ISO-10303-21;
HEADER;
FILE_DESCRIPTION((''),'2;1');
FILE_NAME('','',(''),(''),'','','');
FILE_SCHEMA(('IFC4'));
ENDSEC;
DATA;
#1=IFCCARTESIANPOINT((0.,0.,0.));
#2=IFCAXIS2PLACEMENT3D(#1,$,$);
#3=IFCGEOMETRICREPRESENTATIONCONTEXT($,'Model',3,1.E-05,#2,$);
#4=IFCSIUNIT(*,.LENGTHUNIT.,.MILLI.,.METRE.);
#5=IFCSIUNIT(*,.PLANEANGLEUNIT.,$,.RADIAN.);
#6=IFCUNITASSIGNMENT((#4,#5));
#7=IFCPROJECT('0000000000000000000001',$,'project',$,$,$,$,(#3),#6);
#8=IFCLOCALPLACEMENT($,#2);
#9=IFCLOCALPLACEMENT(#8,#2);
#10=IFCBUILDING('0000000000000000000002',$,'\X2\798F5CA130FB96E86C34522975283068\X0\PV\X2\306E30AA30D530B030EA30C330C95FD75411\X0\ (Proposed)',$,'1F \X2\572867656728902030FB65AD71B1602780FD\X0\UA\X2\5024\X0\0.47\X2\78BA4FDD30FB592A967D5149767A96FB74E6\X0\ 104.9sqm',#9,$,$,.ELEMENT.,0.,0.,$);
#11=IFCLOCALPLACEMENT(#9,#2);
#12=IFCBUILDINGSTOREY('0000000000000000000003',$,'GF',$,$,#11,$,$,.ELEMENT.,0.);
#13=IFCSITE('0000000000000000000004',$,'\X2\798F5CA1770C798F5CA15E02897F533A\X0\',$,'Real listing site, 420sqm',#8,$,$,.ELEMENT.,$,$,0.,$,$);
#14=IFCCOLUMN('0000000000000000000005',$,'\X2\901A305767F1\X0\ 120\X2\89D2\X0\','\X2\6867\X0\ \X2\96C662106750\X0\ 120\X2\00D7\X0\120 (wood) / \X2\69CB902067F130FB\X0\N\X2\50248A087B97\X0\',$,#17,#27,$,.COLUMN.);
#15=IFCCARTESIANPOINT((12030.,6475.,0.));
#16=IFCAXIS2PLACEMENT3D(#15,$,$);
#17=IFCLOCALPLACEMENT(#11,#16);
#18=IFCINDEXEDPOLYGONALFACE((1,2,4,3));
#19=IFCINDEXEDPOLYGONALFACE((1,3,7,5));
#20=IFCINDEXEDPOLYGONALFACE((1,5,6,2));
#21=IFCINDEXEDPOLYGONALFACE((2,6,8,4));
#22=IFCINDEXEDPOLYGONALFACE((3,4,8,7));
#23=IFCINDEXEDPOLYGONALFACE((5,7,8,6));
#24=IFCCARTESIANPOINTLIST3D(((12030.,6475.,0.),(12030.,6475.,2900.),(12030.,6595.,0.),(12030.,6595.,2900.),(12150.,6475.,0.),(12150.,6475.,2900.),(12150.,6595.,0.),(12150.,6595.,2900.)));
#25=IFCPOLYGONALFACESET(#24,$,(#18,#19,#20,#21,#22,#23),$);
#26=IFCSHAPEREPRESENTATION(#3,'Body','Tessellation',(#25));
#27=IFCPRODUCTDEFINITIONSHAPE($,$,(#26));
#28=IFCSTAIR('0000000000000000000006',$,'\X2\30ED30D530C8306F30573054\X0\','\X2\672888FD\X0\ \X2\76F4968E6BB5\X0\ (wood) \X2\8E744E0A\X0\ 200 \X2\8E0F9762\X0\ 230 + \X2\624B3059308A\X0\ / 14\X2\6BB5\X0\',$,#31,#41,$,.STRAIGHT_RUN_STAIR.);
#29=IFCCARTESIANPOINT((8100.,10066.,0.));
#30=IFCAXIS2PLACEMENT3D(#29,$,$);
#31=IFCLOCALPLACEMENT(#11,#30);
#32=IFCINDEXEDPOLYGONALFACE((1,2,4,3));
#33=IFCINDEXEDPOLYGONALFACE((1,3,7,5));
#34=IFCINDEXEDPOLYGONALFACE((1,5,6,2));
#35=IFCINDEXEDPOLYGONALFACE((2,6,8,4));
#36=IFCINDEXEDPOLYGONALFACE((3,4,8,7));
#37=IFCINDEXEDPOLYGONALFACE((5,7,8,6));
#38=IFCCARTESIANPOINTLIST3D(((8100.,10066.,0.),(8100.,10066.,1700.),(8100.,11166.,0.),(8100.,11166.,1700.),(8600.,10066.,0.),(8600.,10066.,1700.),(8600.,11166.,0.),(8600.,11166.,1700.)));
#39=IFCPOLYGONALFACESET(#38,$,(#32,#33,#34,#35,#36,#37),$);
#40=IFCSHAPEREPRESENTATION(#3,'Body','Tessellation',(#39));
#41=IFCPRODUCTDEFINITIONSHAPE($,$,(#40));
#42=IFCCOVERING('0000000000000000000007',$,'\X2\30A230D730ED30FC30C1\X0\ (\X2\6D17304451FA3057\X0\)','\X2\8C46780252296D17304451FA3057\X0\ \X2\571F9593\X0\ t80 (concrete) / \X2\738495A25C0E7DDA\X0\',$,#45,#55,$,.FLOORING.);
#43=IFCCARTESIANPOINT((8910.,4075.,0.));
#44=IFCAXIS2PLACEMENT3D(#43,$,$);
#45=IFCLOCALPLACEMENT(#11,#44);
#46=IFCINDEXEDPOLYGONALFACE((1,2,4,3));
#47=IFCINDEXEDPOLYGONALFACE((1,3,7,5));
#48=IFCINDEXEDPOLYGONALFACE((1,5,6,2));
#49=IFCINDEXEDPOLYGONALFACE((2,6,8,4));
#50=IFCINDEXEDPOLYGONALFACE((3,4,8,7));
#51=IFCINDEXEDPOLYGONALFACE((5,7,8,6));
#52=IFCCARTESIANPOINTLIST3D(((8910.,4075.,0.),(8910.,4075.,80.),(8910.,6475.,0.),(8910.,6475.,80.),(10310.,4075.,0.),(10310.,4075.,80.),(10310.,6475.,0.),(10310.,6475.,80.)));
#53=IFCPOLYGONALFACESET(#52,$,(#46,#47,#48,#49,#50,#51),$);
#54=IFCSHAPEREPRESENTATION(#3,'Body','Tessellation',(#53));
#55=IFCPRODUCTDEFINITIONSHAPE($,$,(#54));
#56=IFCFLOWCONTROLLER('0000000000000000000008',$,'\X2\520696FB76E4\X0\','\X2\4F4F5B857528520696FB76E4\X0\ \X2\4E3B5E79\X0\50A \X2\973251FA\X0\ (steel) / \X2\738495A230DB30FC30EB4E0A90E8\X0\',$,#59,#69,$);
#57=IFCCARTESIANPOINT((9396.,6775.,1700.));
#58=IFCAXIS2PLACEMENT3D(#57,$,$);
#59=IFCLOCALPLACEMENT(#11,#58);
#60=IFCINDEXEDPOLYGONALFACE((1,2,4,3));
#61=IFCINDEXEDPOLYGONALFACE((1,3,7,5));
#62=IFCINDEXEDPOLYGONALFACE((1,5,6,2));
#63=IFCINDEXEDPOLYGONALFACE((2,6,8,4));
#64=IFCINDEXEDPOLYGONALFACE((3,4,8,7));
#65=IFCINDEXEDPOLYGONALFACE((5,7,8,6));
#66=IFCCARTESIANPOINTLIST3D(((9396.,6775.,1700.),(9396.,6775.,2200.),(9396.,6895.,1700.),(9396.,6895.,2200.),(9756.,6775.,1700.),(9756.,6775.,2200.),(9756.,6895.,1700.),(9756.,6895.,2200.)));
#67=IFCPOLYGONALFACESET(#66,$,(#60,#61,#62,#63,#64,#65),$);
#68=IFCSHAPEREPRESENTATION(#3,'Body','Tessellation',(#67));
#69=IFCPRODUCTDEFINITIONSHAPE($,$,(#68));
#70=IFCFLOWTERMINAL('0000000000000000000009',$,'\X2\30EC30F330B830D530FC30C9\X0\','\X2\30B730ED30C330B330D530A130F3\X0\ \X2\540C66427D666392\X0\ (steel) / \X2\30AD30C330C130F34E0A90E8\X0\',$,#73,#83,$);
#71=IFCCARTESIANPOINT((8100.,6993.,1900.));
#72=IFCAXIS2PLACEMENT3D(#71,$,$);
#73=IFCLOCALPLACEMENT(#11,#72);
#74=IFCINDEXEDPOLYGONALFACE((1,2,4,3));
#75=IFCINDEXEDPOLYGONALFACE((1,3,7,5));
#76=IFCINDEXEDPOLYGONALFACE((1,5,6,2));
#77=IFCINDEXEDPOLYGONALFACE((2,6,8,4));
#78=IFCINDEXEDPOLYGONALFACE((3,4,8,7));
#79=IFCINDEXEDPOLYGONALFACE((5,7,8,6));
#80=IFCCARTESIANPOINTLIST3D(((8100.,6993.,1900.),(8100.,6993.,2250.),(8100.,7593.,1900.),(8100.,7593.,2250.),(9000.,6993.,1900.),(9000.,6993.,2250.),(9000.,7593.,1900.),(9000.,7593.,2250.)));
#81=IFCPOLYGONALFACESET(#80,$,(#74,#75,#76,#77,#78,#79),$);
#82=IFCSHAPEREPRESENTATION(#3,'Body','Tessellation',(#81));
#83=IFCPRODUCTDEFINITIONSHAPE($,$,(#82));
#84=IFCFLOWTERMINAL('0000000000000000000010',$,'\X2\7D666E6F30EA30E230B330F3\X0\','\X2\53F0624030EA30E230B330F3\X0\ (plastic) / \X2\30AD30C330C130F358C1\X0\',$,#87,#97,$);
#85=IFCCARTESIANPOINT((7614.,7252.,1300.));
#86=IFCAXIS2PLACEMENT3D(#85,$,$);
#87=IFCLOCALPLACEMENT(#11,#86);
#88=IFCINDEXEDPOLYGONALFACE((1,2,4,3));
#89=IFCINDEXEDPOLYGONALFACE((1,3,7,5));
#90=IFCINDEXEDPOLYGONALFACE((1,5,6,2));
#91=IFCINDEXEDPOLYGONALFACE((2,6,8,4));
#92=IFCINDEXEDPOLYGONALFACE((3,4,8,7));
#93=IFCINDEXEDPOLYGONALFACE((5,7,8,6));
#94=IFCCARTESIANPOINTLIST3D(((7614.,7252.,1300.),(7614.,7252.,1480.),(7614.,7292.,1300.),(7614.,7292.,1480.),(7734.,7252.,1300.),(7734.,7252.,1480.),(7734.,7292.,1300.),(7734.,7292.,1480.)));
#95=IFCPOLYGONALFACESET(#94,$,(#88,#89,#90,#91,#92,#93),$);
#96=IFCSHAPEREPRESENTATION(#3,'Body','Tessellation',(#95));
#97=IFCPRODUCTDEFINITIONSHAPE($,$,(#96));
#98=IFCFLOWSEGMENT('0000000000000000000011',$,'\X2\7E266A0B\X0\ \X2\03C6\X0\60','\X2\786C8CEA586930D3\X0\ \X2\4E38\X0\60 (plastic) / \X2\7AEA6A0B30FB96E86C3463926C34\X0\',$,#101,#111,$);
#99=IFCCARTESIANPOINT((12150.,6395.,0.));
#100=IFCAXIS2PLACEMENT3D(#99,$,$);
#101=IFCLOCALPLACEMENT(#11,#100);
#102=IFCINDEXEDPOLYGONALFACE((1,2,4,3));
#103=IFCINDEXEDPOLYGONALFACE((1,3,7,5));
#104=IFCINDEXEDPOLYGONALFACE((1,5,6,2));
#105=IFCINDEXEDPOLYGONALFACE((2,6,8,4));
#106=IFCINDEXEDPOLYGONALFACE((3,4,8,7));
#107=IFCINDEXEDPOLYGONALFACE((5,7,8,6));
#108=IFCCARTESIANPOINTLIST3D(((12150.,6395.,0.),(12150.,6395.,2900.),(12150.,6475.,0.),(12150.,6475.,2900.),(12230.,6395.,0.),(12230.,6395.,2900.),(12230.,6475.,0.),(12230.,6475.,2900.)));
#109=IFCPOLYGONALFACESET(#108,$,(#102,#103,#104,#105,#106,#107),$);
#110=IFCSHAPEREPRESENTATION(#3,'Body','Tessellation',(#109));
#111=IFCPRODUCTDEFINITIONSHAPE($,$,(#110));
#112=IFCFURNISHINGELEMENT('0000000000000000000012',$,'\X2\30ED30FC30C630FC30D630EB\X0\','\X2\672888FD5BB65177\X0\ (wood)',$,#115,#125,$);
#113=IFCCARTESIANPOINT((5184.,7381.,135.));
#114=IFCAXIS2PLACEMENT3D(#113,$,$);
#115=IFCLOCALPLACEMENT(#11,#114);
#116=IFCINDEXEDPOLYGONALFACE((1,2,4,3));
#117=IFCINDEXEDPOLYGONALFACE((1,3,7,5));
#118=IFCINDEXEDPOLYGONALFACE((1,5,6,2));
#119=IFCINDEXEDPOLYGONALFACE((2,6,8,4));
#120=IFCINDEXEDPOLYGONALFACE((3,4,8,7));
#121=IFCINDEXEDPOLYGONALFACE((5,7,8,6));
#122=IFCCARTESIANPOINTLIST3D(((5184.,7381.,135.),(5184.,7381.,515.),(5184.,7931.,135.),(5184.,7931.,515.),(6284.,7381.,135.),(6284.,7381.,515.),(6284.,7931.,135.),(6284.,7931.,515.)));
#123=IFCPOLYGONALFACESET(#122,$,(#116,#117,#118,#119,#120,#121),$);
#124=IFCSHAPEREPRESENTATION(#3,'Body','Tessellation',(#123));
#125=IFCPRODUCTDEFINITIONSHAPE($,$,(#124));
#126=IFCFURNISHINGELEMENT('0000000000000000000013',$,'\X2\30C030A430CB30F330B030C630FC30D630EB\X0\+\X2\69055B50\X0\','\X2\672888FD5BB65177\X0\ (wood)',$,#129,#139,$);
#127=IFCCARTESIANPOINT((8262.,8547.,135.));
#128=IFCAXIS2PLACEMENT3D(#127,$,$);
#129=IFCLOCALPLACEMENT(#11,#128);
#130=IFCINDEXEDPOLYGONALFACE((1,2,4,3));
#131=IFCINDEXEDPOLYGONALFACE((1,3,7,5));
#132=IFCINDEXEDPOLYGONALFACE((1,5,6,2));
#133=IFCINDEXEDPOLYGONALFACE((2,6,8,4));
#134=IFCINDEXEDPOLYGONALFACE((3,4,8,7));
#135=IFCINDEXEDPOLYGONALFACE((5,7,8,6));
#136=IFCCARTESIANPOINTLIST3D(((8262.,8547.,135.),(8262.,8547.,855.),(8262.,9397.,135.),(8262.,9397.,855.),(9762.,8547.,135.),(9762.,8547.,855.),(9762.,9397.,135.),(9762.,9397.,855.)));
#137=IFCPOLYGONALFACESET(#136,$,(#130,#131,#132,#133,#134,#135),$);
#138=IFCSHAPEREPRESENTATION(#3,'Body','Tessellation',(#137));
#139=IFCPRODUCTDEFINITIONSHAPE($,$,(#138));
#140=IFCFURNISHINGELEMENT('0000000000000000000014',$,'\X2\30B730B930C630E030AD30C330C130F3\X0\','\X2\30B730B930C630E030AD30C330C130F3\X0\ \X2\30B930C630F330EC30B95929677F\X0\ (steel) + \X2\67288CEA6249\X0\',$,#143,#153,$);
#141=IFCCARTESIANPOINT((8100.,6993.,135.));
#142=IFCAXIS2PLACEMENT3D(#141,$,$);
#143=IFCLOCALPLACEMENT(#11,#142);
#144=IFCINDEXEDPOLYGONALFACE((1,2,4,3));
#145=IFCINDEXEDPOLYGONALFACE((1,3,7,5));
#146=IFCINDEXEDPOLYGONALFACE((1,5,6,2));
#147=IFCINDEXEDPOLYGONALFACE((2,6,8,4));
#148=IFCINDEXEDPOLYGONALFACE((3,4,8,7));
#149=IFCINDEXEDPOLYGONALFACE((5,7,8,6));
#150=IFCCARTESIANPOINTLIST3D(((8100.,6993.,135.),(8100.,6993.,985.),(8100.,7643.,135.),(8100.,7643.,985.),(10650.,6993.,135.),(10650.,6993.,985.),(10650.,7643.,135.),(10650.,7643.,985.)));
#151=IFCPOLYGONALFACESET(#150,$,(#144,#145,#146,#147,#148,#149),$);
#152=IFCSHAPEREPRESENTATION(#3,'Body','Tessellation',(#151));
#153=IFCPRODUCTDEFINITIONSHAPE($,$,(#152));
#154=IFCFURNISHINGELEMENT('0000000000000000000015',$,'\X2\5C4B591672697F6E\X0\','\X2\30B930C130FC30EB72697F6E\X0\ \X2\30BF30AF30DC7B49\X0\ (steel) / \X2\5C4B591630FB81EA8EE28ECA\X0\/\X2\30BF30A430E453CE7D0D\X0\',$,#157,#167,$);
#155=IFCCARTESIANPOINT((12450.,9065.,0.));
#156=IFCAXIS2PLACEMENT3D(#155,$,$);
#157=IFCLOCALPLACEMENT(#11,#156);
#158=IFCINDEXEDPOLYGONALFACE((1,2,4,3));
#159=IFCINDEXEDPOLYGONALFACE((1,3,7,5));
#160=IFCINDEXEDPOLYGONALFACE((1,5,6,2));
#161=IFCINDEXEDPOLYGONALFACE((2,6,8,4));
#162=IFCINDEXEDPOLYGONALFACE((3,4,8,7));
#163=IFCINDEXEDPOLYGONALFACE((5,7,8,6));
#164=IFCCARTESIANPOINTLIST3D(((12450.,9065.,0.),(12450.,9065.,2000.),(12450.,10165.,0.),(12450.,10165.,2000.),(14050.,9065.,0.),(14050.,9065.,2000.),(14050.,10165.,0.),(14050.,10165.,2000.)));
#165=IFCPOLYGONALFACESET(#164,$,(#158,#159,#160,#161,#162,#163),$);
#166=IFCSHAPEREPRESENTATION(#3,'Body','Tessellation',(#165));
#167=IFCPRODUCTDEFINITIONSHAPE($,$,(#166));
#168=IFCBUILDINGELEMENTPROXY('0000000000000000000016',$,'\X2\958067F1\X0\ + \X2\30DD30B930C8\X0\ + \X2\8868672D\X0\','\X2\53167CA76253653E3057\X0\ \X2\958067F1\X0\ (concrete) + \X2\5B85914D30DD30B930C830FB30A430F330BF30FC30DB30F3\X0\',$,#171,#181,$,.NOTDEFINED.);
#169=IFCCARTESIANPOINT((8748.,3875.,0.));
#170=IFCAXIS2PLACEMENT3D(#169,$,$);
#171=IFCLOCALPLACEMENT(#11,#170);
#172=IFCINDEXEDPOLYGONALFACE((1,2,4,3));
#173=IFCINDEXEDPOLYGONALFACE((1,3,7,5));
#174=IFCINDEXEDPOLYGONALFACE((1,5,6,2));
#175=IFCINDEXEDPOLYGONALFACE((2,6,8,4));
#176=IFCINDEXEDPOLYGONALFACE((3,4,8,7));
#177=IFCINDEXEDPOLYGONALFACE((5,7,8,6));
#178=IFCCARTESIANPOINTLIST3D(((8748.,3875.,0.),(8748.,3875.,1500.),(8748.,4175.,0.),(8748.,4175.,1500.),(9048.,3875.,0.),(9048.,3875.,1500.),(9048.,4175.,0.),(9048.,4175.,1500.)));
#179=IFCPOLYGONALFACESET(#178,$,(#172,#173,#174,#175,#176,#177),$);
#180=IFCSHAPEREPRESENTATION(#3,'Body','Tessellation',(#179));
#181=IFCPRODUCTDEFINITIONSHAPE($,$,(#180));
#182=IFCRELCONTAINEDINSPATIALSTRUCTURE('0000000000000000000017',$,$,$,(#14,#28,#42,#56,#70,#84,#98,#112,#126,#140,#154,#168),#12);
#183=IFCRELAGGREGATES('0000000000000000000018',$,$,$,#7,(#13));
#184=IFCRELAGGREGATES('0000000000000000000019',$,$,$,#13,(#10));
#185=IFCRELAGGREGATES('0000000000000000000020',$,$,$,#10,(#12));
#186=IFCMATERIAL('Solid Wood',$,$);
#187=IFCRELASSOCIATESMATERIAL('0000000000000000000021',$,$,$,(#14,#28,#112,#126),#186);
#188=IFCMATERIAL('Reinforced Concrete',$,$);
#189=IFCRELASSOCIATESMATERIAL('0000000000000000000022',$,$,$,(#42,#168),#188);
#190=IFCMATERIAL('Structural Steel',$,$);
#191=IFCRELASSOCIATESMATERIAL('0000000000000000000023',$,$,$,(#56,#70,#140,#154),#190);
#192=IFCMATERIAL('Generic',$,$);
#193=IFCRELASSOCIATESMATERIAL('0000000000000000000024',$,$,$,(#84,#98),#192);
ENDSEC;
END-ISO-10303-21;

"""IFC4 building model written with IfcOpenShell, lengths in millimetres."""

from ifc_helpers import new_model, si_unit, frame, frame_2d, origin, place, context, project, spatial, rectangle, extrude, material, element, save


model = new_model("IFC4")

# Units and contexts
model_context = context("Model", 3, precision=1e-05, world=origin())
ifc_project = project(units=[si_unit("LENGTHUNIT", "METRE", prefix="MILLI"), si_unit("PLANEANGLEUNIT", "RADIAN")], contexts=[model_context])

# Site, building, storey
site_placement = place(None, origin())
site = spatial("IfcSite", under=ifc_project, at=site_placement, Name="福岡県福岡市西区", ObjectType="Real listing site, 420sqm", CompositionType="ELEMENT", RefElevation=0.0)
building_placement = place(site_placement, origin())
building = spatial("IfcBuilding", under=site, at=building_placement, Name="福岡・雨水利用とPVのオフグリッド志向 (Proposed)", ObjectType="1F 在来木造・断熱性能UA値0.47確保・太陽光発電瓦 104.9sqm", CompositionType="ELEMENT", ElevationOfRefHeight=0.0, ElevationOfTerrain=0.0)
storey_placement = place(building_placement, origin())
storey = spatial("IfcBuildingStorey", under=building, at=storey_placement, Name="GF", CompositionType="ELEMENT", Elevation=0.0)

# Column
ifc_material_1 = material(Name="Solid Wood")
column_1_placement = place(storey_placement, frame((12030.0, 6475.0, 0.0)))
element("IfcColumn", 1, at=column_1_placement, inside=storey, material=ifc_material_1, Name="通し柱 120角", Description="桧 集成材 120×120 (wood) / 構造柱・N値計算", PredefinedType="COLUMN", context=model_context, shape_type="SweptSolid", body=[
    extrude(rectangle(XDim=120.0, YDim=120.0, at=frame_2d((60.0, 60.0))), frame((12030.0, 6475.0, 0.0)), (0.0, 0.0, 1.0), 2900.0),
])

# Stair
stair_placement = place(storey_placement, frame((8100.0, 10066.0, 0.0)))
element("IfcStair", 2, at=stair_placement, inside=storey, material=ifc_material_1, Name="ロフトはしご", Description="木製 直階段 (wood) 蹴上 200 踏面 230 + 手すり / 14段", PredefinedType="STRAIGHT_RUN_STAIR", context=model_context, shape_type="SweptSolid", body=[
    extrude(rectangle(XDim=500.0, YDim=1100.0, at=frame_2d((250.0, 550.0))), frame((8100.0, 10066.0, 0.0)), (0.0, 0.0, 1.0), 1700.0),
])

# Covering
ifc_material_2 = material(Name="Reinforced Concrete")
covering_placement = place(storey_placement, frame((8910.0, 4075.0, 0.0)))
element("IfcCovering", 3, at=covering_placement, inside=storey, material=ifc_material_2, Name="アプローチ (洗い出し)", Description="豆砂利洗い出し 土間 t80 (concrete) / 玄関導線", PredefinedType="FLOORING", context=model_context, shape_type="SweptSolid", body=[
    extrude(rectangle(XDim=1400.0, YDim=2400.0, at=frame_2d((700.0, 1200.0))), frame((8910.0, 4075.0, 0.0)), (0.0, 0.0, 1.0), 80.0),
])

# Flow controller
ifc_material_3 = material(Name="Structural Steel")
flow_controller_placement = place(storey_placement, frame((9396.0, 6775.0, 1700.0)))
element("IfcFlowController", 4, at=flow_controller_placement, inside=storey, material=ifc_material_3, Name="分電盤", Description="住宅用分電盤 主幹50A 露出 (steel) / 玄関ホール上部", context=model_context, shape_type="SweptSolid", body=[
    extrude(rectangle(XDim=360.0, YDim=120.0, at=frame_2d((180.0, 60.0))), frame((9396.0, 6775.0, 1700.0)), (0.0, 0.0, 1.0), 500.0),
])

# Flow terminals
flow_terminal_1_placement = place(storey_placement, frame((8100.0, 6993.0, 1900.0)))
element("IfcFlowTerminal", 5, at=flow_terminal_1_placement, inside=storey, material=ifc_material_3, Name="レンジフード", Description="シロッコファン 同時給排 (steel) / キッチン上部", context=model_context, shape_type="SweptSolid", body=[
    extrude(rectangle(XDim=900.0, YDim=600.0, at=frame_2d((450.0, 300.0))), frame((8100.0, 6993.0, 1900.0)), (0.0, 0.0, 1.0), 350.0),
])
ifc_material_4 = material(Name="Generic")
flow_terminal_2_placement = place(storey_placement, frame((7614.0, 7252.0, 1300.0)))
element("IfcFlowTerminal", 6, at=flow_terminal_2_placement, inside=storey, material=ifc_material_4, Name="給湯リモコン", Description="台所リモコン (plastic) / キッチン壁", context=model_context, shape_type="SweptSolid", body=[
    extrude(rectangle(XDim=120.0, YDim=40.0, at=frame_2d((60.0, 20.0))), frame((7614.0, 7252.0, 1300.0)), (0.0, 0.0, 1.0), 180.0),
])

# Flow segment
flow_segment_placement = place(storey_placement, frame((12150.0, 6395.0, 0.0)))
element("IfcFlowSegment", 7, at=flow_segment_placement, inside=storey, material=ifc_material_4, Name="縦樋 φ60", Description="硬質塩ビ 丸60 (plastic) / 竪樋・雨水排水", context=model_context, shape_type="SweptSolid", body=[
    extrude(rectangle(XDim=80.0, YDim=80.0, at=frame_2d((40.0, 40.0))), frame((12150.0, 6395.0, 0.0)), (0.0, 0.0, 1.0), 2900.0),
])

# Furnishing elements
furnishing_1_placement = place(storey_placement, frame((5184.0, 7381.0, 135.0)))
element("IfcFurnishingElement", 8, at=furnishing_1_placement, inside=storey, material=ifc_material_1, Name="ローテーブル", Description="木製家具 (wood)", context=model_context, shape_type="SweptSolid", body=[
    extrude(rectangle(XDim=1100.0, YDim=550.0, at=frame_2d((550.0, 275.0))), frame((5184.0, 7381.0, 135.0)), (0.0, 0.0, 1.0), 380.0),
])
furnishing_2_placement = place(storey_placement, frame((8262.0, 8547.0, 135.0)))
element("IfcFurnishingElement", 9, at=furnishing_2_placement, inside=storey, material=ifc_material_1, Name="ダイニングテーブル+椅子", Description="木製家具 (wood)", context=model_context, shape_type="SweptSolid", body=[
    extrude(rectangle(XDim=1500.0, YDim=850.0, at=frame_2d((750.0, 425.0))), frame((8262.0, 8547.0, 135.0)), (0.0, 0.0, 1.0), 720.0),
])
furnishing_3_placement = place(storey_placement, frame((8100.0, 6993.0, 135.0)))
element("IfcFurnishingElement", 10, at=furnishing_3_placement, inside=storey, material=ifc_material_3, Name="システムキッチン", Description="システムキッチン ステンレス天板 (steel) + 木質扉", context=model_context, shape_type="SweptSolid", body=[
    extrude(rectangle(XDim=2550.0, YDim=650.0, at=frame_2d((1275.0, 325.0))), frame((8100.0, 6993.0, 135.0)), (0.0, 0.0, 1.0), 850.0),
])
furnishing_4_placement = place(storey_placement, frame((12450.0, 9065.0, 0.0)))
element("IfcFurnishingElement", 11, at=furnishing_4_placement, inside=storey, material=ifc_material_3, Name="屋外物置", Description="スチール物置 タクボ等 (steel) / 屋外・自転車/タイヤ収納", context=model_context, shape_type="SweptSolid", body=[
    extrude(rectangle(XDim=1600.0, YDim=1100.0, at=frame_2d((800.0, 550.0))), frame((12450.0, 9065.0, 0.0)), (0.0, 0.0, 1.0), 2000.0),
])

# Building element proxy
proxy_placement = place(storey_placement, frame((8748.0, 3875.0, 0.0)))
element("IfcBuildingElementProxy", 12, at=proxy_placement, inside=storey, material=ifc_material_2, Name="門柱 + ポスト + 表札", Description="化粧打放し 門柱 (concrete) + 宅配ポスト・インターホン", PredefinedType="NOTDEFINED", context=model_context, shape_type="SweptSolid", body=[
    extrude(rectangle(XDim=300.0, YDim=300.0, at=frame_2d((150.0, 150.0))), frame((8748.0, 3875.0, 0.0)), (0.0, 0.0, 1.0), 1500.0),
])

save(model, "model.ifc")
